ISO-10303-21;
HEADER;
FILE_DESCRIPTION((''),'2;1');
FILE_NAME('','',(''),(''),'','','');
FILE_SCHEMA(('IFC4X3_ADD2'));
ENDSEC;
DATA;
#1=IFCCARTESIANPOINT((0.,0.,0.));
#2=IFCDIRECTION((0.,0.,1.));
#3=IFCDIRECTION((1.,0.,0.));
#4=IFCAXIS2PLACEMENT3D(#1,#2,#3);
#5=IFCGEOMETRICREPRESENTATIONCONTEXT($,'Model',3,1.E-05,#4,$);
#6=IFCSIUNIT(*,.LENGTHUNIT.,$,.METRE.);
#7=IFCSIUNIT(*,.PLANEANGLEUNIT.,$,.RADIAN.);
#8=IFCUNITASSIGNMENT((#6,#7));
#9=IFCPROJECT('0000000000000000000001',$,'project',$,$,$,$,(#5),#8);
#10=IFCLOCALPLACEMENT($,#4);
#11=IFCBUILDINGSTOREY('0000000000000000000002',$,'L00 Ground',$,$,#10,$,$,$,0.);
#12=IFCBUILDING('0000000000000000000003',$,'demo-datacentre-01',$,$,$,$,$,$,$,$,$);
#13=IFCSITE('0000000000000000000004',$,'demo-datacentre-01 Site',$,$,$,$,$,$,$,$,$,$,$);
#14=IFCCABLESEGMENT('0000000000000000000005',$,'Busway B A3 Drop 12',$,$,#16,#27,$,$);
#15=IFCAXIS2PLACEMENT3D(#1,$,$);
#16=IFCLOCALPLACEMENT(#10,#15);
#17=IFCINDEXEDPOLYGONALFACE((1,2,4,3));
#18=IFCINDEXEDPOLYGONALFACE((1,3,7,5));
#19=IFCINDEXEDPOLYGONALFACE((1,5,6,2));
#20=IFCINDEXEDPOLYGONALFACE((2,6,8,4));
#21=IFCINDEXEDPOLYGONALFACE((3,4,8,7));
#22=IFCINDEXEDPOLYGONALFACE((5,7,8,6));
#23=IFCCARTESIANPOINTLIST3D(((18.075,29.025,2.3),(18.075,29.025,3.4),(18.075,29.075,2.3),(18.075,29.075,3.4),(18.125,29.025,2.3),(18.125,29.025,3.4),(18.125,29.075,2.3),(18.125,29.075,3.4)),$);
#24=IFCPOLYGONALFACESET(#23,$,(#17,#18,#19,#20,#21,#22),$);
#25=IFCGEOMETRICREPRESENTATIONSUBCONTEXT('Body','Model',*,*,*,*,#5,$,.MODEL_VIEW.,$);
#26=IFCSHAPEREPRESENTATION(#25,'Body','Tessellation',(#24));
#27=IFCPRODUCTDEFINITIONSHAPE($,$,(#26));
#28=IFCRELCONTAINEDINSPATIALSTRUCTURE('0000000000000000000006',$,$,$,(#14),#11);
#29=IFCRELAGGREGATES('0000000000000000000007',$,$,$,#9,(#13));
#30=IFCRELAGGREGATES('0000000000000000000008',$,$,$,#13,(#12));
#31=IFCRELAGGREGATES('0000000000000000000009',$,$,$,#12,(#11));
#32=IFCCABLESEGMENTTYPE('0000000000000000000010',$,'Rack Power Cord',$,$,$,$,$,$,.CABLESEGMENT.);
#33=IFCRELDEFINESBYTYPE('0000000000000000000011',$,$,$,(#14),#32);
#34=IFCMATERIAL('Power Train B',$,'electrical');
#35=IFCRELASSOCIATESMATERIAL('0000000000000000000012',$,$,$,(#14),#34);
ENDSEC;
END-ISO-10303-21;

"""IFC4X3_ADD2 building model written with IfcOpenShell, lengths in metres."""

from ifc_helpers import new_model, si_unit, frame, origin_with_axes, place, context, subcontext, project, spatial, rectangle, extrude, material, type_object, element, save


model = new_model("IFC4X3_ADD2")

# Units and contexts
model_context = context("Model", 3, precision=1e-05, world=origin_with_axes())
body_context = subcontext(model_context, "Body", "Model", "MODEL_VIEW")
ifc_project = project(units=[si_unit("LENGTHUNIT", "METRE"), si_unit("PLANEANGLEUNIT", "RADIAN")], contexts=[model_context])

# Site, building, storey
site = spatial("IfcSite", under=ifc_project, Name="demo-datacentre-01 Site")
building = spatial("IfcBuilding", under=site, Name="demo-datacentre-01")
storey_placement = place(None, origin_with_axes())
storey = spatial("IfcBuildingStorey", under=building, at=storey_placement, Name="L00 Ground", Elevation=0.0)

# Shared definitions
ifc_material_1 = material(Name="Power Train B", Category="electrical")

# Cable segment
cable_segment_type_1 = type_object("IfcCableSegmentType", Name="Rack Power Cord", PredefinedType="CABLESEGMENT")
for number, where, z_axis, x_axis, name in (
    (1, (18.1, 29.05, 3.4), (0.0, 0.0, -1.0), (1.0, 0.0, 0.0), "Busway B A3 Drop 12"),
):
    element("IfcCableSegment", number, at=place(storey_placement, frame(where, z_axis=z_axis, x_axis=x_axis)), inside=storey, type_object=cable_segment_type_1, material=ifc_material_1, Name=name, context=body_context, shape_type="SweptSolid", body=[
        extrude(rectangle(XDim=0.05, YDim=0.05), origin_with_axes(), (0.0, 0.0, 1.0), 1.1),
    ])

save(model, "model.ifc")
